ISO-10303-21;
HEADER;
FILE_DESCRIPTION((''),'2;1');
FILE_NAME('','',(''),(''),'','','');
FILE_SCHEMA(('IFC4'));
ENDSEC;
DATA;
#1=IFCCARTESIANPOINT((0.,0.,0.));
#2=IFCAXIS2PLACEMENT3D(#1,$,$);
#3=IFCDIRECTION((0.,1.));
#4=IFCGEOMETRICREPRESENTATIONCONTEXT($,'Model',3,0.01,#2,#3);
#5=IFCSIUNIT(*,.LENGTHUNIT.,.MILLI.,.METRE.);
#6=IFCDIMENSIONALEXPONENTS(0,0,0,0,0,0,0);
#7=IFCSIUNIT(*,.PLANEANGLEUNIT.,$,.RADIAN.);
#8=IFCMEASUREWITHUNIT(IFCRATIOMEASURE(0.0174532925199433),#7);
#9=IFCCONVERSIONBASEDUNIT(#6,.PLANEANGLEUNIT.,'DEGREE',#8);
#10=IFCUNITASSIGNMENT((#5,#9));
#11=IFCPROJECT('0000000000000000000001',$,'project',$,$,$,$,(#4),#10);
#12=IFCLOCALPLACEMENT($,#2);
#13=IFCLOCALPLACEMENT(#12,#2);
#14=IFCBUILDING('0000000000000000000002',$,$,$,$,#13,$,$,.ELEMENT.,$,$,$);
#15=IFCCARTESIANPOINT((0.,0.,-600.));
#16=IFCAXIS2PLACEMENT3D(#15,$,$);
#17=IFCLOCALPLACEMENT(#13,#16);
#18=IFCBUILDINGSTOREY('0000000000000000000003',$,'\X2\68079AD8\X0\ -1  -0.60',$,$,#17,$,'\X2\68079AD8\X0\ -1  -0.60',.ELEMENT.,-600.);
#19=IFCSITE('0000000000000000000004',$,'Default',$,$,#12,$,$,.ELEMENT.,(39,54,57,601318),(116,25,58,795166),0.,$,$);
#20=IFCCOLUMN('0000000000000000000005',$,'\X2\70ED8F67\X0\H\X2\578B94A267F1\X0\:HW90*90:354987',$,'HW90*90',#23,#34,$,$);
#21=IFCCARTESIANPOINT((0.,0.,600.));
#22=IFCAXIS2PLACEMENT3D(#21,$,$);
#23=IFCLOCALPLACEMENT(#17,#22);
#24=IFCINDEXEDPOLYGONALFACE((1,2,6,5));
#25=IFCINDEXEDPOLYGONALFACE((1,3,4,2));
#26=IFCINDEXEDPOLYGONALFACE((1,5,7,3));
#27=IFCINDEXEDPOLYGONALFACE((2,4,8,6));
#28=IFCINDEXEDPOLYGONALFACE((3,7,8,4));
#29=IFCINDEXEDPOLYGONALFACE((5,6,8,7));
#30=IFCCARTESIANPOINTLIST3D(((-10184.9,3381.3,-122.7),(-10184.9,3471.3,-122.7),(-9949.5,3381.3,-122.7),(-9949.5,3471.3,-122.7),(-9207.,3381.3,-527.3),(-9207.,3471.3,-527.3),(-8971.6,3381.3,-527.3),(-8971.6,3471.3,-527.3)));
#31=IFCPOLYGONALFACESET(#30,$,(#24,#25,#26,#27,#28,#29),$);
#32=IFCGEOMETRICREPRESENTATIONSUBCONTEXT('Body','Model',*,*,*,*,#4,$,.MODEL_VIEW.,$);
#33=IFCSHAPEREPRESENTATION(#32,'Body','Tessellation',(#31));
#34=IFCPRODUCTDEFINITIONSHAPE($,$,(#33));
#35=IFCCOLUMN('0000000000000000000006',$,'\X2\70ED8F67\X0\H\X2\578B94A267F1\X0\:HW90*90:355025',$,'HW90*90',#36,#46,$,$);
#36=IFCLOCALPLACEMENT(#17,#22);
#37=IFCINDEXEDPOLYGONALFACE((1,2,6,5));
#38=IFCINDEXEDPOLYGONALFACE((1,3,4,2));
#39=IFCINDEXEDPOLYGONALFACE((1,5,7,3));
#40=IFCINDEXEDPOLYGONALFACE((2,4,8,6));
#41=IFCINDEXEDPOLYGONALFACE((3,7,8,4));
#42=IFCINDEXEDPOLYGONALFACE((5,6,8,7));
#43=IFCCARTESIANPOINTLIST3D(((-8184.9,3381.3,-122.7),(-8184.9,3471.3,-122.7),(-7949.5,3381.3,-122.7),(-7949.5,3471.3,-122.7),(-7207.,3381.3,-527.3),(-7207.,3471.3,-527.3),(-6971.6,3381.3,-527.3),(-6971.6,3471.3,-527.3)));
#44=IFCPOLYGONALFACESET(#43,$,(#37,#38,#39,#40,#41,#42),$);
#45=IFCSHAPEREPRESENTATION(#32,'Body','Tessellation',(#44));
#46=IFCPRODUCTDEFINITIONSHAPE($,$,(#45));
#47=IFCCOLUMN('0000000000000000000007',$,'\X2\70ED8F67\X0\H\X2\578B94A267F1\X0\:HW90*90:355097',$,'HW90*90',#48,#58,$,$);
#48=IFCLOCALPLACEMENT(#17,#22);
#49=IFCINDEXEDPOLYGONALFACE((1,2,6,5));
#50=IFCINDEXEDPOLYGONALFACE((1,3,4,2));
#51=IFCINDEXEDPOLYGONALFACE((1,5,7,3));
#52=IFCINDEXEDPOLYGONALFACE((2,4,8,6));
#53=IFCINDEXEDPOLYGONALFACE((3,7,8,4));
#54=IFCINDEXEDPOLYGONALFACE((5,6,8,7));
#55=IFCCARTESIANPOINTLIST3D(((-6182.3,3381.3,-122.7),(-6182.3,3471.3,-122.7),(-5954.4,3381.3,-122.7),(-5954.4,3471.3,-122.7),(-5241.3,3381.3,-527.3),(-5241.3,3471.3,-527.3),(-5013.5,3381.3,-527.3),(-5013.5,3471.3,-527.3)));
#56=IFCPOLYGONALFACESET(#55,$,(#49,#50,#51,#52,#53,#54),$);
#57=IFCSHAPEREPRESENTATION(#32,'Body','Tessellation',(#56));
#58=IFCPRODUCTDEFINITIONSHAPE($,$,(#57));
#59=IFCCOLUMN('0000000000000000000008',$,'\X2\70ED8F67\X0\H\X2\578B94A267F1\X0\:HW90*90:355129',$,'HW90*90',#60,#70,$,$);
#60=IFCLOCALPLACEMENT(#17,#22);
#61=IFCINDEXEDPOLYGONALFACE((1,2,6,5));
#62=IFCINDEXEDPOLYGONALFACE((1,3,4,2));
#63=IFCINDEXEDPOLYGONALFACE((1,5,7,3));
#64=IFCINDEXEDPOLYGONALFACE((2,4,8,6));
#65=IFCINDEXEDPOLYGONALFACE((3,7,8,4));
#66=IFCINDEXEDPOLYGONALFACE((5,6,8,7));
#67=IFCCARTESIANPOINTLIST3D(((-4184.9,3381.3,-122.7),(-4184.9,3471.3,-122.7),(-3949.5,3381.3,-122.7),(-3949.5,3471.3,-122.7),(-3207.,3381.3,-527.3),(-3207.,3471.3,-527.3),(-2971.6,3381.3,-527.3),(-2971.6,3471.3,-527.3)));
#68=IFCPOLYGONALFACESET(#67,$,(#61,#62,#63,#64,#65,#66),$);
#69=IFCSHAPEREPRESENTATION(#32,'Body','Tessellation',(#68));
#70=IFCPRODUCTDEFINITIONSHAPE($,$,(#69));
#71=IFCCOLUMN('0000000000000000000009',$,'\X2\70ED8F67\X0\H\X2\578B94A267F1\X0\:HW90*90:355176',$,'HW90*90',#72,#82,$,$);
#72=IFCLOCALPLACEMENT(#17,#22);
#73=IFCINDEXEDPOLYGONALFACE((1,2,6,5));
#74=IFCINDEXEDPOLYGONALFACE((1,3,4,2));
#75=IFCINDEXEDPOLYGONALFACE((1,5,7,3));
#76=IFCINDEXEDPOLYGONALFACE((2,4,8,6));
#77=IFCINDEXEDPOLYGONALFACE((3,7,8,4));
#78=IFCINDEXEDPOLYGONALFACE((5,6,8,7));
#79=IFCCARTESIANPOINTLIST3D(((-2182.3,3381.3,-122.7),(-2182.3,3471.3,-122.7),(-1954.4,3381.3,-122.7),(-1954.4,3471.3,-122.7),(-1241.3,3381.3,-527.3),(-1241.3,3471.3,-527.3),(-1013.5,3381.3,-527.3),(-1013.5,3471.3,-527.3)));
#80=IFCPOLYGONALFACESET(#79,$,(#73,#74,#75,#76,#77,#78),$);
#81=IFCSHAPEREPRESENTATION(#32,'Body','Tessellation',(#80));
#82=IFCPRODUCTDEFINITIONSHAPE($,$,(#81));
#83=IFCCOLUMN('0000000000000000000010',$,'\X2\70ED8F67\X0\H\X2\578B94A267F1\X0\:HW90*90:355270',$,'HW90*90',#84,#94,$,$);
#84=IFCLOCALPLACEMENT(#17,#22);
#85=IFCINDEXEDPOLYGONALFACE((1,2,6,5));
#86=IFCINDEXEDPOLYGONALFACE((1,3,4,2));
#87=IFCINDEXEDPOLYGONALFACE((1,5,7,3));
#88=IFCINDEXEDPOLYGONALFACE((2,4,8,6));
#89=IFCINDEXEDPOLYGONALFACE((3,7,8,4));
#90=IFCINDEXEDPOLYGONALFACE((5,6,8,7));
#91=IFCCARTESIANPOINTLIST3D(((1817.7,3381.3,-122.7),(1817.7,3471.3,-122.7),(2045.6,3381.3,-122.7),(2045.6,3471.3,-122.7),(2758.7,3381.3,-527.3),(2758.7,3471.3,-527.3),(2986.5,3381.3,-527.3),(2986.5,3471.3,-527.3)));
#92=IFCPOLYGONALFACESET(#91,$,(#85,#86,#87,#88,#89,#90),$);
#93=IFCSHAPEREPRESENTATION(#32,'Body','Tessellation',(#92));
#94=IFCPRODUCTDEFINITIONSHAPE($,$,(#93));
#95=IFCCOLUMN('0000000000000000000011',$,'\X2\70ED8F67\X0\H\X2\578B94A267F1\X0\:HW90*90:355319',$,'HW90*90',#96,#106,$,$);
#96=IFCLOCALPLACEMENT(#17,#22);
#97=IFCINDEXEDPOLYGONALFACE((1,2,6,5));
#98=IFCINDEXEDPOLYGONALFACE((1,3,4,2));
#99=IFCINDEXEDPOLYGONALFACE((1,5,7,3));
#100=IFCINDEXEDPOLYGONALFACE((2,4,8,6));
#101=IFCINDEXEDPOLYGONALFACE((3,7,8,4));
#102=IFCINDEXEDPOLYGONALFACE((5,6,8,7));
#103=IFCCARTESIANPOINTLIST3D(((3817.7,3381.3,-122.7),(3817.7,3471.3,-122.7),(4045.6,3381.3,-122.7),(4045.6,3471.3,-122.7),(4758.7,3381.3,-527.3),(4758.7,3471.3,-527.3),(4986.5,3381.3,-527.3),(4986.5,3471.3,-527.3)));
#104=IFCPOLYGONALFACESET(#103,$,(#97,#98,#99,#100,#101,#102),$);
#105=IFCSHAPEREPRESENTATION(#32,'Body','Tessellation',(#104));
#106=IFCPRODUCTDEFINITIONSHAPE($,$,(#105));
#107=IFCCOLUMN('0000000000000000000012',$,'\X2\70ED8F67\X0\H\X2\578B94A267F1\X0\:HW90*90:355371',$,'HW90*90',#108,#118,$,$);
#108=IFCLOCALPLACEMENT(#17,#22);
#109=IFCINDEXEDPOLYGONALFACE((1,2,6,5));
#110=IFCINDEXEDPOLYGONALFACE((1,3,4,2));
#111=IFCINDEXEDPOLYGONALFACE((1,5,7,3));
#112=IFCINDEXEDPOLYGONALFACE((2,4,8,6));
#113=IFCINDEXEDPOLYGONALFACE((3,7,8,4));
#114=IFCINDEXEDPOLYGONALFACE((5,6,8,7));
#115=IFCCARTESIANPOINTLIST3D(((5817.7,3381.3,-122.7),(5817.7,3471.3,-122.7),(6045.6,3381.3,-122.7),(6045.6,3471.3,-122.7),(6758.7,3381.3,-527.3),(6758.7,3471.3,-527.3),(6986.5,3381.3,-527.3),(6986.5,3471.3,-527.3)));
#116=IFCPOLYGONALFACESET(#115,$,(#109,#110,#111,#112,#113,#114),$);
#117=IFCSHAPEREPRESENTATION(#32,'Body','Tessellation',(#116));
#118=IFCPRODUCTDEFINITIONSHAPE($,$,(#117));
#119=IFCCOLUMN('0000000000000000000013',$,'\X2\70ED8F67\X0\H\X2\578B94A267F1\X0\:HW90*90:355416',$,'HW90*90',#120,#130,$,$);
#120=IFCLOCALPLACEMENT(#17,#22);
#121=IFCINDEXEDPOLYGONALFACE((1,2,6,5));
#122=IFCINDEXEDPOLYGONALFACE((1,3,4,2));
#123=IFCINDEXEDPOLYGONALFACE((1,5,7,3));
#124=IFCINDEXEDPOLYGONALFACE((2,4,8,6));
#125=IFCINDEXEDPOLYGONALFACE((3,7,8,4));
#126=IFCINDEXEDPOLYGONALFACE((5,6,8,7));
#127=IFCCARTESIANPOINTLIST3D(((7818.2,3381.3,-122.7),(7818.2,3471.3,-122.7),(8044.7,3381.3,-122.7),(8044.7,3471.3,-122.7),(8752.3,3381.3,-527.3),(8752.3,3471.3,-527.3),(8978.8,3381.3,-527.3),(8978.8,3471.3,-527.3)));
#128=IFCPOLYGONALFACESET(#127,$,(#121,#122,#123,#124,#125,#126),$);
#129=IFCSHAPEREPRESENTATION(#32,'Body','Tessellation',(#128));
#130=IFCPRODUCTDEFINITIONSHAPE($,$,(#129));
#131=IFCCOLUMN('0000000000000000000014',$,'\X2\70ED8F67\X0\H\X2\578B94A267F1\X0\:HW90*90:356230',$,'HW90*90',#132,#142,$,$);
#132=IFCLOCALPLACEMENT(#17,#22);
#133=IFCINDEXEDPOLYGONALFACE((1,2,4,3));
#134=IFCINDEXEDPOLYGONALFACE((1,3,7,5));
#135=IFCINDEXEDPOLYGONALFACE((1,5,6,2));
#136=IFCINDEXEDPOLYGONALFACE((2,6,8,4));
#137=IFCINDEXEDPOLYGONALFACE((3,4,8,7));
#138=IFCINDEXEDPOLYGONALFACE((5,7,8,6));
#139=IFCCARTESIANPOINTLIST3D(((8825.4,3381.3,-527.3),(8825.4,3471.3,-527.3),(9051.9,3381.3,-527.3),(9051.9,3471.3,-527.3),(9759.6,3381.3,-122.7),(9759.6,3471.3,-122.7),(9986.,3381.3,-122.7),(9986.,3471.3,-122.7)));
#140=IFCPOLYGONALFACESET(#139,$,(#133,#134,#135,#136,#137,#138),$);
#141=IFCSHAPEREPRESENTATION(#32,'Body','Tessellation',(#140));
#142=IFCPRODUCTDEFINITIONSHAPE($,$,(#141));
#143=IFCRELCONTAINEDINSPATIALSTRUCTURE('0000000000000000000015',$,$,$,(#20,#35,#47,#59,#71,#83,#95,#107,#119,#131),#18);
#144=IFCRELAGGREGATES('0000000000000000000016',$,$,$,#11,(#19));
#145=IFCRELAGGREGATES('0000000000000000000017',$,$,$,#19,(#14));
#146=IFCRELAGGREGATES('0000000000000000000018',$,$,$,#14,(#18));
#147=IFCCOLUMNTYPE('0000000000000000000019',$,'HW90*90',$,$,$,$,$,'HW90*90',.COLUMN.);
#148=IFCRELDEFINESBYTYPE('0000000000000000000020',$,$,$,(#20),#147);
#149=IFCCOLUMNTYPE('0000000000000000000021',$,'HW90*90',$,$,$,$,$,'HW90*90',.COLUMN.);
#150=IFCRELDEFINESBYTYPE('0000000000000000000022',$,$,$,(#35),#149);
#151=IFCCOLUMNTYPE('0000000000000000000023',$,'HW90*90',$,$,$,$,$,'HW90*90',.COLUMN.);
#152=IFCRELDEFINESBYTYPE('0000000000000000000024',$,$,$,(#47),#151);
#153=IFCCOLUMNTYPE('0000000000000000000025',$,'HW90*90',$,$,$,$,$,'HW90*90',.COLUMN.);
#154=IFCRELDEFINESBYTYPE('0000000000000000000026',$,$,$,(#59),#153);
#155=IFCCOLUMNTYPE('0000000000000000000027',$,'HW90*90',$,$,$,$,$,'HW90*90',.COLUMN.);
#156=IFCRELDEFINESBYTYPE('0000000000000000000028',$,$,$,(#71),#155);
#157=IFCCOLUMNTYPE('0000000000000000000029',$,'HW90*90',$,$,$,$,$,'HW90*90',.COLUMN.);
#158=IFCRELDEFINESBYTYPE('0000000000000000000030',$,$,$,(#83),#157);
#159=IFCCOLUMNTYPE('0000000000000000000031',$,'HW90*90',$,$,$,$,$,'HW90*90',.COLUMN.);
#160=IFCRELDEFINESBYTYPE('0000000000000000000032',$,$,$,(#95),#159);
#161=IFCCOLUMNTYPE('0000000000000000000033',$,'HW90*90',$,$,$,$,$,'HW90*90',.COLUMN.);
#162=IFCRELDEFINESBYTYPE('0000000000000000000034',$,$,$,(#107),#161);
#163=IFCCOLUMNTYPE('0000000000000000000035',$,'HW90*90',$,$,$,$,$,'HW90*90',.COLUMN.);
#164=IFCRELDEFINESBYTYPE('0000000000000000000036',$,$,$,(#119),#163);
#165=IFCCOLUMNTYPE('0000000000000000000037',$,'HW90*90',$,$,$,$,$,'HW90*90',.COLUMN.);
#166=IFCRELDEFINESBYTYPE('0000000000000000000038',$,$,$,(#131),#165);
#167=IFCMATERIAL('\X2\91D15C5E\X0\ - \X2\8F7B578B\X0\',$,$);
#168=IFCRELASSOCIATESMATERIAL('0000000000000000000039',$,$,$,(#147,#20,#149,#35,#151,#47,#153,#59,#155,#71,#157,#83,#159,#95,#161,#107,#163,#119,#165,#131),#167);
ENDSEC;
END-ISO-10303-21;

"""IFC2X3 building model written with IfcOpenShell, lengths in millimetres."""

from ifc_helpers import new_model, entity, si_unit, converted_unit, direction, frame, frame_2d, origin, origin_2d_with_axis, place, context, subcontext, project, spatial, rectangle, extrude, clip, halfspace, source, transform, mapped, material, type_object, type_shapes, element, save


model = new_model("IFC2X3")

# Units and contexts
model_context = context("Model", 3, precision=0.01, world=origin(), true_north=direction((0.0, 1.0)))
body_context = subcontext(model_context, "Body", "Model", "MODEL_VIEW")
ifc_project = project(units=[si_unit("LENGTHUNIT", "METRE", prefix="MILLI"), converted_unit("PLANEANGLEUNIT", "DEGREE", entity("IfcRatioMeasure", 0.0174532925199433), si_unit("PLANEANGLEUNIT", "RADIAN"), dimensions=[0, 0, 0, 0, 0, 0, 0])], contexts=[model_context])

# Site, building, storey
site_placement = place(None, origin())
site = spatial("IfcSite", under=ifc_project, at=site_placement, Name="Default", CompositionType="ELEMENT", RefLatitude=(39, 54, 57, 601318), RefLongitude=(116, 25, 58, 795166), RefElevation=0.0)
building_placement = place(site_placement, origin())
building = spatial("IfcBuilding", under=site, at=building_placement, CompositionType="ELEMENT")
storey_placement = place(building_placement, frame((0.0, 0.0, -600.0)))
storey = spatial("IfcBuildingStorey", under=building, at=storey_placement, Name="标高 -1  -0.60", LongName="标高 -1  -0.60", CompositionType="ELEMENT", Elevation=-600.0)

# Columns
ifc_material = material(Name="金属 - 轻型")
column_type_1 = type_object("IfcColumnType", Name="HW90*90", ElementType="HW90*90", PredefinedType="COLUMN", material=ifc_material)
shared_shape_1 = source(origin(), body_context, "Body", "Clipping", [
    clip(clip(extrude(rectangle(XDim=90.0, YDim=1213.2, at=frame_2d((0.0, 0.0), x_axis=(1.0, 0.0))), frame((-9578.3, 3426.3, -527.3), z_axis=(0.0, 0.0, 1.0), x_axis=(0.0, -1.0, 0.0)), (0.0, 0.0, 1.0), 404.6), halfspace(frame((-10392.0, 3471.3, -37.0), z_axis=(-0.382332, 0.0, -0.924025), x_axis=(0.924025, 0.0, -0.382332)), False)), halfspace(frame((-10357.6, 3381.3, 46.2), z_axis=(0.382332, 0.0, 0.924025), x_axis=(0.924025, 0.0, -0.382332)), False)),
])
type_shapes(column_type_1, [shared_shape_1])
column_1_placement = place(storey_placement, frame((0.0, 0.0, 600.0)))
element("IfcColumn", 1, at=column_1_placement, inside=storey, type_object=column_type_1, material=ifc_material, Name="热轧H型钢柱:HW90*90:354987", ObjectType="HW90*90", context=body_context, shape_type="MappedRepresentation", body=[
    mapped(shared_shape_1, transform((0.0, 0.0, 0.0), scale=1.0)),
])
column_type_2 = type_object("IfcColumnType", Name="HW90*90", ElementType="HW90*90", PredefinedType="COLUMN", material=ifc_material)
shared_shape_2 = source(origin(), body_context, "Body", "Clipping", [
    clip(clip(extrude(rectangle(XDim=90.0, YDim=1213.2, at=frame_2d((0.0, 0.0), x_axis=(1.0, 0.0))), frame((-7578.3, 3426.3, -527.3), z_axis=(0.0, 0.0, 1.0), x_axis=(0.0, -1.0, 0.0)), (0.0, 0.0, 1.0), 404.6), halfspace(frame((-8392.0, 3471.3, -37.0), z_axis=(-0.382332, 0.0, -0.924025), x_axis=(0.924025, 0.0, -0.382332)), False)), halfspace(frame((-8357.6, 3381.3, 46.2), z_axis=(0.382332, 0.0, 0.924025), x_axis=(0.924025, 0.0, -0.382332)), False)),
])
type_shapes(column_type_2, [shared_shape_2])
column_2_placement = place(storey_placement, frame((0.0, 0.0, 600.0)))
element("IfcColumn", 2, at=column_2_placement, inside=storey, type_object=column_type_2, material=ifc_material, Name="热轧H型钢柱:HW90*90:355025", ObjectType="HW90*90", context=body_context, shape_type="MappedRepresentation", body=[
    mapped(shared_shape_2, transform((0.0, 0.0, 0.0), scale=1.0)),
])
column_type_3 = type_object("IfcColumnType", Name="HW90*90", ElementType="HW90*90", PredefinedType="COLUMN", material=ifc_material)
shared_shape_3 = source(origin(), body_context, "Body", "Clipping", [
    clip(clip(extrude(rectangle(XDim=90.0, YDim=1168.8, at=frame_2d((0.0, 0.0), x_axis=(1.0, 0.0))), frame((-5597.9, 3426.3, -527.3), z_axis=(0.0, 0.0, 1.0), x_axis=(0.0, -1.0, 0.0)), (0.0, 0.0, 1.0), 404.6), halfspace(frame((-6346.6, 3381.3, 45.9), z_axis=(0.395028, 0.0, 0.918669), x_axis=(0.918669, 0.0, -0.395028)), False)), halfspace(frame((-6382.1, 3471.3, -36.8), z_axis=(-0.395028, 0.0, -0.918669), x_axis=(0.918669, 0.0, -0.395028)), False)),
])
type_shapes(column_type_3, [shared_shape_3])
column_3_placement = place(storey_placement, frame((0.0, 0.0, 600.0)))
element("IfcColumn", 3, at=column_3_placement, inside=storey, type_object=column_type_3, material=ifc_material, Name="热轧H型钢柱:HW90*90:355097", ObjectType="HW90*90", context=body_context, shape_type="MappedRepresentation", body=[
    mapped(shared_shape_3, transform((0.0, 0.0, 0.0), scale=1.0)),
])
column_type_4 = type_object("IfcColumnType", Name="HW90*90", ElementType="HW90*90", PredefinedType="COLUMN", material=ifc_material)
shared_shape_4 = source(origin(), body_context, "Body", "Clipping", [
    clip(clip(extrude(rectangle(XDim=90.0, YDim=1213.2, at=frame_2d((0.0, 0.0), x_axis=(1.0, 0.0))), frame((-3578.3, 3426.3, -527.3), z_axis=(0.0, 0.0, 1.0), x_axis=(0.0, -1.0, 0.0)), (0.0, 0.0, 1.0), 404.6), halfspace(frame((-4392.0, 3471.3, -37.0), z_axis=(-0.382332, 0.0, -0.924025), x_axis=(0.924025, 0.0, -0.382332)), False)), halfspace(frame((-4357.6, 3381.3, 46.2), z_axis=(0.382332, 0.0, 0.924025), x_axis=(0.924025, 0.0, -0.382332)), False)),
])
type_shapes(column_type_4, [shared_shape_4])
column_4_placement = place(storey_placement, frame((0.0, 0.0, 600.0)))
element("IfcColumn", 4, at=column_4_placement, inside=storey, type_object=column_type_4, material=ifc_material, Name="热轧H型钢柱:HW90*90:355129", ObjectType="HW90*90", context=body_context, shape_type="MappedRepresentation", body=[
    mapped(shared_shape_4, transform((0.0, 0.0, 0.0), scale=1.0)),
])
column_type_5 = type_object("IfcColumnType", Name="HW90*90", ElementType="HW90*90", PredefinedType="COLUMN", material=ifc_material)
shared_shape_5 = source(origin(), body_context, "Body", "Clipping", [
    clip(clip(extrude(rectangle(XDim=90.0, YDim=1168.8, at=frame_2d((0.0, 0.0), x_axis=(1.0, 0.0))), frame((-1597.9, 3426.3, -527.3), z_axis=(0.0, 0.0, 1.0), x_axis=(0.0, -1.0, 0.0)), (0.0, 0.0, 1.0), 404.6), halfspace(frame((-2346.6, 3381.3, 45.9), z_axis=(0.395028, 0.0, 0.918669), x_axis=(0.918669, 0.0, -0.395028)), False)), halfspace(frame((-2382.1, 3471.3, -36.8), z_axis=(-0.395028, 0.0, -0.918669), x_axis=(0.918669, 0.0, -0.395028)), False)),
])
type_shapes(column_type_5, [shared_shape_5])
column_5_placement = place(storey_placement, frame((0.0, 0.0, 600.0)))
element("IfcColumn", 5, at=column_5_placement, inside=storey, type_object=column_type_5, material=ifc_material, Name="热轧H型钢柱:HW90*90:355176", ObjectType="HW90*90", context=body_context, shape_type="MappedRepresentation", body=[
    mapped(shared_shape_5, transform((0.0, 0.0, 0.0), scale=1.0)),
])
column_type_6 = type_object("IfcColumnType", Name="HW90*90", ElementType="HW90*90", PredefinedType="COLUMN", material=ifc_material)
shared_shape_6 = source(origin(), body_context, "Body", "Clipping", [
    clip(clip(extrude(rectangle(XDim=90.0, YDim=1168.8, at=origin_2d_with_axis()), frame((2402.1, 3426.3, -527.3), z_axis=(0.0, 0.0, 1.0), x_axis=(0.0, -1.0, 0.0)), (0.0, 0.0, 1.0), 404.6), halfspace(frame((1653.4, 3381.3, 45.9), z_axis=(0.395028, 0.0, 0.918669), x_axis=(0.918669, 0.0, -0.395028)), False)), halfspace(frame((1617.9, 3471.3, -36.8), z_axis=(-0.395028, 0.0, -0.918669), x_axis=(0.918669, 0.0, -0.395028)), False)),
])
type_shapes(column_type_6, [shared_shape_6])
column_6_placement = place(storey_placement, frame((0.0, 0.0, 600.0)))
element("IfcColumn", 6, at=column_6_placement, inside=storey, type_object=column_type_6, material=ifc_material, Name="热轧H型钢柱:HW90*90:355270", ObjectType="HW90*90", context=body_context, shape_type="MappedRepresentation", body=[
    mapped(shared_shape_6, transform((0.0, 0.0, 0.0), scale=1.0)),
])
column_type_7 = type_object("IfcColumnType", Name="HW90*90", ElementType="HW90*90", PredefinedType="COLUMN", material=ifc_material)
shared_shape_7 = source(origin(), body_context, "Body", "Clipping", [
    clip(clip(extrude(rectangle(XDim=90.0, YDim=1168.8, at=frame_2d((0.0, 0.0), x_axis=(1.0, 0.0))), frame((4402.1, 3426.3, -527.3), z_axis=(0.0, 0.0, 1.0), x_axis=(0.0, -1.0, 0.0)), (0.0, 0.0, 1.0), 404.6), halfspace(frame((3617.9, 3471.3, -36.8), z_axis=(-0.395028, 0.0, -0.918669), x_axis=(0.918669, 0.0, -0.395028)), False)), halfspace(frame((3653.4, 3381.3, 45.9), z_axis=(0.395028, 0.0, 0.918669), x_axis=(0.918669, 0.0, -0.395028)), False)),
])
type_shapes(column_type_7, [shared_shape_7])
column_7_placement = place(storey_placement, frame((0.0, 0.0, 600.0)))
element("IfcColumn", 7, at=column_7_placement, inside=storey, type_object=column_type_7, material=ifc_material, Name="热轧H型钢柱:HW90*90:355319", ObjectType="HW90*90", context=body_context, shape_type="MappedRepresentation", body=[
    mapped(shared_shape_7, transform((0.0, 0.0, 0.0), scale=1.0)),
])
column_type_8 = type_object("IfcColumnType", Name="HW90*90", ElementType="HW90*90", PredefinedType="COLUMN", material=ifc_material)
shared_shape_8 = source(origin(), body_context, "Body", "Clipping", [
    clip(clip(extrude(rectangle(XDim=90.0, YDim=1168.8, at=origin_2d_with_axis()), frame((6402.1, 3426.3, -527.3), z_axis=(0.0, 0.0, 1.0), x_axis=(0.0, -1.0, 0.0)), (0.0, 0.0, 1.0), 404.6), halfspace(frame((5653.4, 3381.3, 45.9), z_axis=(0.395028, 0.0, 0.918669), x_axis=(0.918669, 0.0, -0.395028)), False)), halfspace(frame((5617.9, 3471.3, -36.8), z_axis=(-0.395028, 0.0, -0.918669), x_axis=(0.918669, 0.0, -0.395028)), False)),
])
type_shapes(column_type_8, [shared_shape_8])
column_8_placement = place(storey_placement, frame((0.0, 0.0, 600.0)))
element("IfcColumn", 8, at=column_8_placement, inside=storey, type_object=column_type_8, material=ifc_material, Name="热轧H型钢柱:HW90*90:355371", ObjectType="HW90*90", context=body_context, shape_type="MappedRepresentation", body=[
    mapped(shared_shape_8, transform((0.0, 0.0, 0.0), scale=1.0)),
])
column_type_9 = type_object("IfcColumnType", Name="HW90*90", ElementType="HW90*90", PredefinedType="COLUMN", material=ifc_material)
shared_shape_9 = source(origin(), body_context, "Body", "Clipping", [
    clip(clip(extrude(rectangle(XDim=90.0, YDim=1160.6, at=frame_2d((0.0, 0.0), x_axis=(1.0, 0.0))), frame((8398.5, 3426.3, -527.3), z_axis=(0.0, 0.0, 1.0), x_axis=(0.0, -1.0, 0.0)), (0.0, 0.0, 1.0), 404.6), halfspace(frame((7619.7, 3471.3, -36.7), z_axis=(-0.39745, 0.0, -0.917624), x_axis=(0.917624, 0.0, -0.39745)), False)), halfspace(frame((7655.5, 3381.3, 45.9), z_axis=(0.39745, 0.0, 0.917624), x_axis=(0.917624, 0.0, -0.39745)), False)),
])
type_shapes(column_type_9, [shared_shape_9])
column_9_placement = place(storey_placement, frame((0.0, 0.0, 600.0)))
element("IfcColumn", 9, at=column_9_placement, inside=storey, type_object=column_type_9, material=ifc_material, Name="热轧H型钢柱:HW90*90:355416", ObjectType="HW90*90", context=body_context, shape_type="MappedRepresentation", body=[
    mapped(shared_shape_9, transform((0.0, 0.0, 0.0), scale=1.0)),
])
column_type_10 = type_object("IfcColumnType", Name="HW90*90", ElementType="HW90*90", PredefinedType="COLUMN", material=ifc_material)
shared_shape_10 = source(origin(), body_context, "Body", "Clipping", [
    clip(clip(extrude(rectangle(XDim=90.0, YDim=1160.6, at=origin_2d_with_axis()), frame((9405.7, 3426.3, -527.3), z_axis=(0.0, 0.0, 1.0), x_axis=(0.0, -1.0, 0.0)), (0.0, 0.0, 1.0), 404.6), halfspace(frame((10184.5, 3381.3, -36.7), z_axis=(0.39745, 0.0, -0.917624), x_axis=(-0.917624, 0.0, -0.39745)), False)), halfspace(frame((10148.8, 3471.3, 45.9), z_axis=(-0.39745, 0.0, 0.917624), x_axis=(-0.917624, 0.0, -0.39745)), False)),
])
type_shapes(column_type_10, [shared_shape_10])
column_10_placement = place(storey_placement, frame((0.0, 0.0, 600.0)))
element("IfcColumn", 10, at=column_10_placement, inside=storey, type_object=column_type_10, material=ifc_material, Name="热轧H型钢柱:HW90*90:356230", ObjectType="HW90*90", context=body_context, shape_type="MappedRepresentation", body=[
    mapped(shared_shape_10, transform((0.0, 0.0, 0.0), scale=1.0)),
])

save(model, "model.ifc")
